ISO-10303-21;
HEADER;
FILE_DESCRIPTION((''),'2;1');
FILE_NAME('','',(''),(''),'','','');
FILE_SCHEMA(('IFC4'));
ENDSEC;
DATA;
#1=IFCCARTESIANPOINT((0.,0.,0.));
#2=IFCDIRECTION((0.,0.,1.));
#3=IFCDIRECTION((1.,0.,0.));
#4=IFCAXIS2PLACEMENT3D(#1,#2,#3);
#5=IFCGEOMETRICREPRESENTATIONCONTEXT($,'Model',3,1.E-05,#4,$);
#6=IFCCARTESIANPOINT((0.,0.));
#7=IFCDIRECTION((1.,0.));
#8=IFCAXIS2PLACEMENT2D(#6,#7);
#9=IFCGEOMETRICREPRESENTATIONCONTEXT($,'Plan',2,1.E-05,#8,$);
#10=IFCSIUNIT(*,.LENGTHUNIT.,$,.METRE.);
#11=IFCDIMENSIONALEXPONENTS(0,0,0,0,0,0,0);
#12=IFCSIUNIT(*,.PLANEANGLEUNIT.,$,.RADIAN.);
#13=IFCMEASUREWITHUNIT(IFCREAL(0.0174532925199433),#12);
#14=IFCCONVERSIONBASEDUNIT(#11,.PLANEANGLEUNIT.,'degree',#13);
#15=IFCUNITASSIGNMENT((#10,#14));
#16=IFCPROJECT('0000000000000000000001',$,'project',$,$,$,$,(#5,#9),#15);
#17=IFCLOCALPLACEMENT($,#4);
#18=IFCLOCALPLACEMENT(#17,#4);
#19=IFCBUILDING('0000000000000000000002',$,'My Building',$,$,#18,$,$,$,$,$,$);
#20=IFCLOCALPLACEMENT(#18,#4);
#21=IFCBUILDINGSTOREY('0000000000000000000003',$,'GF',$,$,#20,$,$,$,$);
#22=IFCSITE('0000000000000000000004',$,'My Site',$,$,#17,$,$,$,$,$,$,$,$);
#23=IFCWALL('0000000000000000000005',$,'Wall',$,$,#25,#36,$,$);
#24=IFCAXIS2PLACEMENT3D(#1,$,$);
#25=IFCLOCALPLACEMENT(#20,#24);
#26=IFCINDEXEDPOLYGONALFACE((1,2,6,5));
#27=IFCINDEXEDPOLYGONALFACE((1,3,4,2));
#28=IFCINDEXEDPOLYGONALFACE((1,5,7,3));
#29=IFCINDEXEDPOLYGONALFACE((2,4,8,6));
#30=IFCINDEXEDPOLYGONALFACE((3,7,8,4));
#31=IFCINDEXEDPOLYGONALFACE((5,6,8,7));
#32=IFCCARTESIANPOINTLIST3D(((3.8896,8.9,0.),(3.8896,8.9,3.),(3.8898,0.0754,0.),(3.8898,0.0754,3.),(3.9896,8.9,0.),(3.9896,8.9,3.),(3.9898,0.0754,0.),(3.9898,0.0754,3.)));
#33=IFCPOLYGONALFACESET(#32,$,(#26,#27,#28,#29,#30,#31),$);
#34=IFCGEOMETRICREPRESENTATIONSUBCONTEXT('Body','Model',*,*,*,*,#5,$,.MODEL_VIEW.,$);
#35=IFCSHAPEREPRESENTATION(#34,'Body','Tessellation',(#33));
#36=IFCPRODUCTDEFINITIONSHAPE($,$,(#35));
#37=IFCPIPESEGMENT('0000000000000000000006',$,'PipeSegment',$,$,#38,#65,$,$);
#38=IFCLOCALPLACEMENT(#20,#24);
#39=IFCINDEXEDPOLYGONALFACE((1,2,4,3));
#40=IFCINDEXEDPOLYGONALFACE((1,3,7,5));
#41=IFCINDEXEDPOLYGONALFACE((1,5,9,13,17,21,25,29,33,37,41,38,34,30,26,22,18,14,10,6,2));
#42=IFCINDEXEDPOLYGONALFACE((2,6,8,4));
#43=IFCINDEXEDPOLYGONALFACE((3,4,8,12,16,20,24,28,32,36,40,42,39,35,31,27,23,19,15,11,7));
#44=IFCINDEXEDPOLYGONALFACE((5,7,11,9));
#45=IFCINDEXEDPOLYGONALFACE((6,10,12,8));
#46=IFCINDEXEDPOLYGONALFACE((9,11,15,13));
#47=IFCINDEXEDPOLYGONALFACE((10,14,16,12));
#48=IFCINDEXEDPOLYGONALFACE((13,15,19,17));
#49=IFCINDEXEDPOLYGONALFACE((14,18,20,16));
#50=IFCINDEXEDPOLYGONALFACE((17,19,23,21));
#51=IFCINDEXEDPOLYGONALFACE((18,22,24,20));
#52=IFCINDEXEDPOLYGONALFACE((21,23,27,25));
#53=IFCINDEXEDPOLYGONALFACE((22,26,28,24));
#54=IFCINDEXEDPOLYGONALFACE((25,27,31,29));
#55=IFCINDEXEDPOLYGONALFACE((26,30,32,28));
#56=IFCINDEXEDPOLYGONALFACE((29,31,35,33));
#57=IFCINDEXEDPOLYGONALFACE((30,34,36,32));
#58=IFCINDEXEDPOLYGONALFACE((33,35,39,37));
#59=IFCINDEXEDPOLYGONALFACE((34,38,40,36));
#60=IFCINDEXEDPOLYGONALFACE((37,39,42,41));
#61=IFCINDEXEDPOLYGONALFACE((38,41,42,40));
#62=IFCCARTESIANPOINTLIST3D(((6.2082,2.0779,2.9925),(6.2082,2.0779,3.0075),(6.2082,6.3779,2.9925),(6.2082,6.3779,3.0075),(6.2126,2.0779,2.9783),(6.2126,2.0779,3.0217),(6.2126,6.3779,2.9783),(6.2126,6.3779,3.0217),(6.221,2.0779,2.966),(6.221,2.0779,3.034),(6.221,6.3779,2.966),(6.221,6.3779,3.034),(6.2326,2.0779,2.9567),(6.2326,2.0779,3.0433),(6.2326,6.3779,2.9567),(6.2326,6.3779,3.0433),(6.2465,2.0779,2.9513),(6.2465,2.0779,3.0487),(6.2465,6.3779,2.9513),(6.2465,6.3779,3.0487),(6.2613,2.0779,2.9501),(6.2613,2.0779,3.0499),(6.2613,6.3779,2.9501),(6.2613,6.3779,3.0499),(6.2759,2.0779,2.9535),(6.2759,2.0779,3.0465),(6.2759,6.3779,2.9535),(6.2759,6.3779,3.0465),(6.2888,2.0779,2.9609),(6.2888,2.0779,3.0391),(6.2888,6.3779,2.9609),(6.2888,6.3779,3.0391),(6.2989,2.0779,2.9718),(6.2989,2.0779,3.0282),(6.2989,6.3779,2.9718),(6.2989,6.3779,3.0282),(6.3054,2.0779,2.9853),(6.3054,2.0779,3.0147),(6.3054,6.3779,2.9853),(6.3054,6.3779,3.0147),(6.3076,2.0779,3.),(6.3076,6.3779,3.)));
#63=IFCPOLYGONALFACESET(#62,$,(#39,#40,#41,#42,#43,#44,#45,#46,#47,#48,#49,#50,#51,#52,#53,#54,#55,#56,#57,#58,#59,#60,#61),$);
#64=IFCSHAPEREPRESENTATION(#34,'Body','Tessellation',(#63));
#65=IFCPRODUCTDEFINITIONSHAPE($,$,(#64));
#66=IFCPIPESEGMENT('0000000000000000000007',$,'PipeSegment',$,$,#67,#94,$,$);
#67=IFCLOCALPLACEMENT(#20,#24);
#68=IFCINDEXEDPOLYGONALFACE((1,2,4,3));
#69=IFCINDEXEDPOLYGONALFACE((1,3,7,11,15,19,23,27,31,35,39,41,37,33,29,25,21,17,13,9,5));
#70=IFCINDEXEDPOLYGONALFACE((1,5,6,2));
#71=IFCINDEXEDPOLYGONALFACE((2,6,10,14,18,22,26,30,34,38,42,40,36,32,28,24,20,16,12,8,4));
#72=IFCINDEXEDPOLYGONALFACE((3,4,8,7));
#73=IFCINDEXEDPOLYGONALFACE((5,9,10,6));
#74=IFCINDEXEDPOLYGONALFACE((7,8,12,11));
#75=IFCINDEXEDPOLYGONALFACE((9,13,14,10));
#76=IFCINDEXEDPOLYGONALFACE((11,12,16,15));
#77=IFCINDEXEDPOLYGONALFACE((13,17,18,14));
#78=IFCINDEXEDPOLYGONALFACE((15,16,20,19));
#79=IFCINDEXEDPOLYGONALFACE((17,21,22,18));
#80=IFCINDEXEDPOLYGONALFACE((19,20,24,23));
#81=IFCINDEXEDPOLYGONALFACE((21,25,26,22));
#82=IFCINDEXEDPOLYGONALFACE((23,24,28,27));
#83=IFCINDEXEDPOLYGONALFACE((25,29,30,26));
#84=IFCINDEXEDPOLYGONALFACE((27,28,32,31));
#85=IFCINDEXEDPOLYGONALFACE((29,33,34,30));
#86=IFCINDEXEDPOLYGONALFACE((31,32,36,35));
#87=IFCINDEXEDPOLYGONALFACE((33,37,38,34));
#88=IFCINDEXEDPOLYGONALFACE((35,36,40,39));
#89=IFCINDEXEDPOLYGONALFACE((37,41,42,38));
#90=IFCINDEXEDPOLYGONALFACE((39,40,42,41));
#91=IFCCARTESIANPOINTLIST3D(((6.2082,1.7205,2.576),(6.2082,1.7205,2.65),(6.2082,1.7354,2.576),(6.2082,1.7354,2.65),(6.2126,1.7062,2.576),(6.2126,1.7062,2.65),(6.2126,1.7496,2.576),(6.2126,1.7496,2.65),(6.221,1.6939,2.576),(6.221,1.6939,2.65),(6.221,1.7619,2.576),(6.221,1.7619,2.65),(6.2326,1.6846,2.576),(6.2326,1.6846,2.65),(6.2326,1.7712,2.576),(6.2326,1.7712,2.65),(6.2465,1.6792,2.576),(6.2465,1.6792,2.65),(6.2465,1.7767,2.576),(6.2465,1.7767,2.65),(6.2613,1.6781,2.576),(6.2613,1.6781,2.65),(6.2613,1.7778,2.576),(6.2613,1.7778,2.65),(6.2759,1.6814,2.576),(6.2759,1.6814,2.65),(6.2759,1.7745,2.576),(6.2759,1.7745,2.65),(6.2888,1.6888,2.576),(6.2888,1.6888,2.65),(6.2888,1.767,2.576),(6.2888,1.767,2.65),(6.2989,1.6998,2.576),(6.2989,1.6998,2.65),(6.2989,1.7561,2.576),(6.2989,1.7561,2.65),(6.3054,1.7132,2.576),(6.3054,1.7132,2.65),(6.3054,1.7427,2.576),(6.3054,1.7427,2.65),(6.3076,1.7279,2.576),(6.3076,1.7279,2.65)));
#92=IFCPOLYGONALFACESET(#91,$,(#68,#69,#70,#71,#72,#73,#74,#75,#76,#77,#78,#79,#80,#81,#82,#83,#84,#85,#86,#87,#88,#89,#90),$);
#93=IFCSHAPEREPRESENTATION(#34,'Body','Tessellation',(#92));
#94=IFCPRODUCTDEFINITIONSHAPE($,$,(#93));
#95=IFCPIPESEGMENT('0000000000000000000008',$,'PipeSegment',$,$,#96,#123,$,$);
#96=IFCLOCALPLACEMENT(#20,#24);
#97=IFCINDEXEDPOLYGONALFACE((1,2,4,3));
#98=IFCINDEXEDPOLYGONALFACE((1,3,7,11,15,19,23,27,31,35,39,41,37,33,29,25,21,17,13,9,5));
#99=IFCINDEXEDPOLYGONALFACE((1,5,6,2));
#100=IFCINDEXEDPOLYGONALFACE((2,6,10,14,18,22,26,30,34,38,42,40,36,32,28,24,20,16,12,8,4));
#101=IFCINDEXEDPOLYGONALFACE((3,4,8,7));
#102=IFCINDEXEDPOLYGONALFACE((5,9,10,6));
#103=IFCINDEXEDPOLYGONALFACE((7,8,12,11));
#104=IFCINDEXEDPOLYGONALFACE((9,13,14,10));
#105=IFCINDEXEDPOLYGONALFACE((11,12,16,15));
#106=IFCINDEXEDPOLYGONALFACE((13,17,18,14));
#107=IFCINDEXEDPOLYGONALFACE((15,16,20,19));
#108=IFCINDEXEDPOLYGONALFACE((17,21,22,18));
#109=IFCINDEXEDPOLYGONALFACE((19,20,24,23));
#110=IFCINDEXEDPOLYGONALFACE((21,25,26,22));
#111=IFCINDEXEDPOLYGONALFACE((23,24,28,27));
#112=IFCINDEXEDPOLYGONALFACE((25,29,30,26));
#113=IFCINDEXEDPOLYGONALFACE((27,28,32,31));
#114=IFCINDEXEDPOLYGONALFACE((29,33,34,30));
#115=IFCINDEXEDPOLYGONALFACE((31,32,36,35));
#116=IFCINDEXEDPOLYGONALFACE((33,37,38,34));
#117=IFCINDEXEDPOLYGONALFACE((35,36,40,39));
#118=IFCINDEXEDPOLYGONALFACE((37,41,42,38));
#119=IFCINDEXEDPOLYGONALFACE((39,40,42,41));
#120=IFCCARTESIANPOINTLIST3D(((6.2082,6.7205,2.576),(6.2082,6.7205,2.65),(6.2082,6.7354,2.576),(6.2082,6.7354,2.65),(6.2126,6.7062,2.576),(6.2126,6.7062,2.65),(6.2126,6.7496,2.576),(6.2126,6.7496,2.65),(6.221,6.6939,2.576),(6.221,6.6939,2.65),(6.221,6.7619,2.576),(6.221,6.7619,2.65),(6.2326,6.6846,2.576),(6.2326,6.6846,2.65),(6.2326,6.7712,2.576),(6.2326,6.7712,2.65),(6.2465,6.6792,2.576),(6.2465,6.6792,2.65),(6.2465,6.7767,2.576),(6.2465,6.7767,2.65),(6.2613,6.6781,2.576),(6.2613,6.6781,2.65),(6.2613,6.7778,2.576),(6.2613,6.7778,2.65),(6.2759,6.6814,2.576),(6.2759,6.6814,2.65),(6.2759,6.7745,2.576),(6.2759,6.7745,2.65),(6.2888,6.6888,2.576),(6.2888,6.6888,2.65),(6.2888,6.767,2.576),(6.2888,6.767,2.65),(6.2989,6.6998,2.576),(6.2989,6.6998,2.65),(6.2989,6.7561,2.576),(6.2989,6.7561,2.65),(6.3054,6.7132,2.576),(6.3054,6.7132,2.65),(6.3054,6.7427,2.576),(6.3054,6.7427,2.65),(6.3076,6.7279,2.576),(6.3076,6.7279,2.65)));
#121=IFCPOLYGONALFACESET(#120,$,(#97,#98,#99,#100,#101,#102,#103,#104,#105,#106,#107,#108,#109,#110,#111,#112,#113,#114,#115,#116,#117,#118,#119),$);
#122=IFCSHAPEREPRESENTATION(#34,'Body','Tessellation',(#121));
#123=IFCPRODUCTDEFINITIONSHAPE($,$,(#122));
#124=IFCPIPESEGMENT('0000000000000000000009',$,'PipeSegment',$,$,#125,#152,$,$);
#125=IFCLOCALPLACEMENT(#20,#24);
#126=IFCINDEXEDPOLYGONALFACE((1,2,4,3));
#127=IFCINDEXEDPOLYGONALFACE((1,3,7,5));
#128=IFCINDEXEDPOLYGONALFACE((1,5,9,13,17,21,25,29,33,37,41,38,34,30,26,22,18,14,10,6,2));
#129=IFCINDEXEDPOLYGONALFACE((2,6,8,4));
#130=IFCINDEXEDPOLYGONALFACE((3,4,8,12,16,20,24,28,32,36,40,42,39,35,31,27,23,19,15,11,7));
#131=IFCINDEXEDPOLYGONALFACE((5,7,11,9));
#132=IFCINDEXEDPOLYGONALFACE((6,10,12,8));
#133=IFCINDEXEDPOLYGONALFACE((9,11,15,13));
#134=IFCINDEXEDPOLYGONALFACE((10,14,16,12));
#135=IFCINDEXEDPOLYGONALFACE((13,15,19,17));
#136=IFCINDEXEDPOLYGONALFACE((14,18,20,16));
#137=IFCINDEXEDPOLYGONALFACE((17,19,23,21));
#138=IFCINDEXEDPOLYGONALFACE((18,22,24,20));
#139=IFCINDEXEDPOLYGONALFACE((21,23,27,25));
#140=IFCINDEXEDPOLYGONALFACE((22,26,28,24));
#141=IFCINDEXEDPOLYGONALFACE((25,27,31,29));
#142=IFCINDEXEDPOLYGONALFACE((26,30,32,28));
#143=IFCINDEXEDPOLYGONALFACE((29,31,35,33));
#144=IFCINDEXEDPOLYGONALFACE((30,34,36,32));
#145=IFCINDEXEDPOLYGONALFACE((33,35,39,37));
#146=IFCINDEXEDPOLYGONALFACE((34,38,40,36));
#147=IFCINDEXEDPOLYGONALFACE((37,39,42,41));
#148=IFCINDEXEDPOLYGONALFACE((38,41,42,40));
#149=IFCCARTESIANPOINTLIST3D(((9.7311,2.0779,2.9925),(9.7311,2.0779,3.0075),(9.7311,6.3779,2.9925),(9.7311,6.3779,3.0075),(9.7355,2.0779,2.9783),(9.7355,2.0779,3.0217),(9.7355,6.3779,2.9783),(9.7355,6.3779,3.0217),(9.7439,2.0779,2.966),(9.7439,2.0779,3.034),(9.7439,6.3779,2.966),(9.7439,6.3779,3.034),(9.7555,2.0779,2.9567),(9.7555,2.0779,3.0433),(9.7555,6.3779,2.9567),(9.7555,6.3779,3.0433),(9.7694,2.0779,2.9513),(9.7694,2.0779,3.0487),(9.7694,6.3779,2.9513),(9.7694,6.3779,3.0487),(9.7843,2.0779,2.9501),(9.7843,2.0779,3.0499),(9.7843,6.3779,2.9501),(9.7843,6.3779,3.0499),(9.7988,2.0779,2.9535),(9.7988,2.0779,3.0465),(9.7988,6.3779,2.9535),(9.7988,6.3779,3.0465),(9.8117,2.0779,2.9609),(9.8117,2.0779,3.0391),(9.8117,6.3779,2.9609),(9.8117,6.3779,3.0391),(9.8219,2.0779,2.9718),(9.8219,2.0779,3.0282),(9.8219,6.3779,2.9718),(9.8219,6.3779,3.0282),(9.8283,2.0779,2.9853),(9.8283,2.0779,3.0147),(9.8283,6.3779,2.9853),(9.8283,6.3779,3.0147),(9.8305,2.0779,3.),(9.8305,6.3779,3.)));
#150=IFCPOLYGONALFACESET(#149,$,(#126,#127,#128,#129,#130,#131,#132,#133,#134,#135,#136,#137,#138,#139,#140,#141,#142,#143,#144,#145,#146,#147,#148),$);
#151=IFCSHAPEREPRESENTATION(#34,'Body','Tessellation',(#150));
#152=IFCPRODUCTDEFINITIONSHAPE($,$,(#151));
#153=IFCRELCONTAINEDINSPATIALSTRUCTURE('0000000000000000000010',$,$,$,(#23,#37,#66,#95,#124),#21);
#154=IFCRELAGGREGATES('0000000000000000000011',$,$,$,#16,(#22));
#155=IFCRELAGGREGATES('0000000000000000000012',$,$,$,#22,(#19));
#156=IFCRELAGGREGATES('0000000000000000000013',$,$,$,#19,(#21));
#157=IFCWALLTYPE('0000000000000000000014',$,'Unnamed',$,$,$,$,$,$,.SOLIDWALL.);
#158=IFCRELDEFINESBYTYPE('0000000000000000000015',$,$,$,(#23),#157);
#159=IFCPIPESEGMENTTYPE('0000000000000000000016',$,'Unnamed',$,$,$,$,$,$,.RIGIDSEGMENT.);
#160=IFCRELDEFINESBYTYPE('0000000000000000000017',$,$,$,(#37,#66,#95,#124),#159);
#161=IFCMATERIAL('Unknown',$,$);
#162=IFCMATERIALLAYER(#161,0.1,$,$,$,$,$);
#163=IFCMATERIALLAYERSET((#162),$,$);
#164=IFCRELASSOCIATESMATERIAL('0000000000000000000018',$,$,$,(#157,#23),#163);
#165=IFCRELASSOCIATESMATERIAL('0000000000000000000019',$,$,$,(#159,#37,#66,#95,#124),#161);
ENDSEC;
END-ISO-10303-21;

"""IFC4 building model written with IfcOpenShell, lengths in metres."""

from ifc_helpers import new_model, entity, si_unit, converted_unit, frame, origin_with_axes, origin_2d_with_axis, place, context, subcontext, project, spatial, line, indexed_curve, circle, outline, extrude, material, layer, layer_set, layer_usage, material_profile, profile_set, profile_usage, type_object, element, save


model = new_model("IFC4")

# Units and contexts
model_context = context("Model", 3, precision=1e-05, world=origin_with_axes())
plan_context = context("Plan", 2, precision=1e-05, world=origin_2d_with_axis())
body_context_1 = subcontext(model_context, "Body", "Model", "MODEL_VIEW")
ifc_project = project(units=[si_unit("LENGTHUNIT", "METRE"), converted_unit("PLANEANGLEUNIT", "degree", entity("IfcReal", 0.0174532925199433), si_unit("PLANEANGLEUNIT", "RADIAN"), dimensions=[0, 0, 0, 0, 0, 0, 0])], contexts=[model_context, plan_context])

# Site, building, storey
site_placement = place(None, origin_with_axes())
site = spatial("IfcSite", under=ifc_project, at=site_placement, Name="My Site")
building_placement = place(site_placement, origin_with_axes())
building = spatial("IfcBuilding", under=site, at=building_placement, Name="My Building")
storey_placement = place(building_placement, origin_with_axes())
storey = spatial("IfcBuildingStorey", under=building, at=storey_placement, Name="GF")

# Wall
ifc_material = material(Name="Unknown")
ifc_layer = layer(ifc_material, 0.1)
ifc_layer_set = layer_set([ifc_layer])
ifc_layer_usage_1 = layer_usage(ifc_layer_set, "AXIS2", "POSITIVE", 0.0)
wall_type = type_object("IfcWallType", Name="Unnamed", PredefinedType="SOLIDWALL", material=ifc_layer_set)
wall_1_placement = place(storey_placement, frame((3.9898, 0.0754, 0.0), z_axis=(0.0, 0.0, 1.0), x_axis=(-0.000021, 1.0, 0.0)))
element("IfcWall", 1, at=wall_1_placement, inside=storey, type_object=wall_type, material=ifc_layer_usage_1, Name="Wall", context=body_context_1, shape_type="SweptSolid", body=[
    extrude(outline(indexed_curve([(0.0, 0.0), (0.0, 0.1), (8.8246, 0.1), (8.8246, 0.0)], segments=[line(1, 2, 3, 4, 1)])), origin_with_axes(), (0.0, 0.0, 1.0), 3.0),
])

# Pipe segments
ifc_material_profile = material_profile(ifc_material, circle(Radius=0.05))
ifc_profile_set = profile_set([ifc_material_profile])
ifc_profile_usage_1 = profile_usage(ifc_profile_set, cardinal=5)
pipe_segment_type = type_object("IfcPipeSegmentType", Name="Unnamed", PredefinedType="RIGIDSEGMENT", material=ifc_profile_set)
pipe_segment_1_placement = place(storey_placement, frame((6.2576, 6.3779, 3.0), z_axis=(0.0, -1.0, 0.0), x_axis=(1.0, 0.0, 0.0)))
element("IfcPipeSegment", 2, at=pipe_segment_1_placement, inside=storey, type_object=pipe_segment_type, material=ifc_profile_usage_1, Name="PipeSegment", context=body_context_1, shape_type="SweptSolid", body=[
    extrude(circle(Radius=0.05), origin_with_axes(), (0.0, 0.0, 1.0), 4.3),
])
ifc_profile_usage_2 = profile_usage(ifc_profile_set, cardinal=5)
pipe_segment_2_placement = place(storey_placement, frame((6.2576, 1.7279, 2.576), z_axis=(0.0, 0.0, 1.0), x_axis=(1.0, 0.0, 0.0)))
element("IfcPipeSegment", 3, at=pipe_segment_2_placement, inside=storey, type_object=pipe_segment_type, material=ifc_profile_usage_2, Name="PipeSegment", context=body_context_1, shape_type="SweptSolid", body=[
    extrude(circle(Radius=0.05), origin_with_axes(), (0.0, 0.0, 1.0), 0.074),
])
ifc_profile_usage_3 = profile_usage(ifc_profile_set, cardinal=5)
pipe_segment_3_placement = place(storey_placement, frame((6.2576, 6.7279, 2.576), z_axis=(0.0, 0.0, 1.0), x_axis=(1.0, 0.0, 0.0)))
element("IfcPipeSegment", 4, at=pipe_segment_3_placement, inside=storey, type_object=pipe_segment_type, material=ifc_profile_usage_3, Name="PipeSegment", context=body_context_1, shape_type="SweptSolid", body=[
    extrude(circle(Radius=0.05), origin_with_axes(), (0.0, 0.0, 1.0), 0.074),
])
ifc_profile_usage_4 = profile_usage(ifc_profile_set, cardinal=5)
pipe_segment_4_placement = place(storey_placement, frame((9.7805, 6.3779, 3.0), z_axis=(0.0, -1.0, 0.0), x_axis=(1.0, 0.0, 0.0)))
element("IfcPipeSegment", 5, at=pipe_segment_4_placement, inside=storey, type_object=pipe_segment_type, material=ifc_profile_usage_4, Name="PipeSegment", context=body_context_1, shape_type="SweptSolid", body=[
    extrude(circle(Radius=0.05), origin_with_axes(), (0.0, 0.0, 1.0), 4.3),
])

save(model, "model.ifc")
